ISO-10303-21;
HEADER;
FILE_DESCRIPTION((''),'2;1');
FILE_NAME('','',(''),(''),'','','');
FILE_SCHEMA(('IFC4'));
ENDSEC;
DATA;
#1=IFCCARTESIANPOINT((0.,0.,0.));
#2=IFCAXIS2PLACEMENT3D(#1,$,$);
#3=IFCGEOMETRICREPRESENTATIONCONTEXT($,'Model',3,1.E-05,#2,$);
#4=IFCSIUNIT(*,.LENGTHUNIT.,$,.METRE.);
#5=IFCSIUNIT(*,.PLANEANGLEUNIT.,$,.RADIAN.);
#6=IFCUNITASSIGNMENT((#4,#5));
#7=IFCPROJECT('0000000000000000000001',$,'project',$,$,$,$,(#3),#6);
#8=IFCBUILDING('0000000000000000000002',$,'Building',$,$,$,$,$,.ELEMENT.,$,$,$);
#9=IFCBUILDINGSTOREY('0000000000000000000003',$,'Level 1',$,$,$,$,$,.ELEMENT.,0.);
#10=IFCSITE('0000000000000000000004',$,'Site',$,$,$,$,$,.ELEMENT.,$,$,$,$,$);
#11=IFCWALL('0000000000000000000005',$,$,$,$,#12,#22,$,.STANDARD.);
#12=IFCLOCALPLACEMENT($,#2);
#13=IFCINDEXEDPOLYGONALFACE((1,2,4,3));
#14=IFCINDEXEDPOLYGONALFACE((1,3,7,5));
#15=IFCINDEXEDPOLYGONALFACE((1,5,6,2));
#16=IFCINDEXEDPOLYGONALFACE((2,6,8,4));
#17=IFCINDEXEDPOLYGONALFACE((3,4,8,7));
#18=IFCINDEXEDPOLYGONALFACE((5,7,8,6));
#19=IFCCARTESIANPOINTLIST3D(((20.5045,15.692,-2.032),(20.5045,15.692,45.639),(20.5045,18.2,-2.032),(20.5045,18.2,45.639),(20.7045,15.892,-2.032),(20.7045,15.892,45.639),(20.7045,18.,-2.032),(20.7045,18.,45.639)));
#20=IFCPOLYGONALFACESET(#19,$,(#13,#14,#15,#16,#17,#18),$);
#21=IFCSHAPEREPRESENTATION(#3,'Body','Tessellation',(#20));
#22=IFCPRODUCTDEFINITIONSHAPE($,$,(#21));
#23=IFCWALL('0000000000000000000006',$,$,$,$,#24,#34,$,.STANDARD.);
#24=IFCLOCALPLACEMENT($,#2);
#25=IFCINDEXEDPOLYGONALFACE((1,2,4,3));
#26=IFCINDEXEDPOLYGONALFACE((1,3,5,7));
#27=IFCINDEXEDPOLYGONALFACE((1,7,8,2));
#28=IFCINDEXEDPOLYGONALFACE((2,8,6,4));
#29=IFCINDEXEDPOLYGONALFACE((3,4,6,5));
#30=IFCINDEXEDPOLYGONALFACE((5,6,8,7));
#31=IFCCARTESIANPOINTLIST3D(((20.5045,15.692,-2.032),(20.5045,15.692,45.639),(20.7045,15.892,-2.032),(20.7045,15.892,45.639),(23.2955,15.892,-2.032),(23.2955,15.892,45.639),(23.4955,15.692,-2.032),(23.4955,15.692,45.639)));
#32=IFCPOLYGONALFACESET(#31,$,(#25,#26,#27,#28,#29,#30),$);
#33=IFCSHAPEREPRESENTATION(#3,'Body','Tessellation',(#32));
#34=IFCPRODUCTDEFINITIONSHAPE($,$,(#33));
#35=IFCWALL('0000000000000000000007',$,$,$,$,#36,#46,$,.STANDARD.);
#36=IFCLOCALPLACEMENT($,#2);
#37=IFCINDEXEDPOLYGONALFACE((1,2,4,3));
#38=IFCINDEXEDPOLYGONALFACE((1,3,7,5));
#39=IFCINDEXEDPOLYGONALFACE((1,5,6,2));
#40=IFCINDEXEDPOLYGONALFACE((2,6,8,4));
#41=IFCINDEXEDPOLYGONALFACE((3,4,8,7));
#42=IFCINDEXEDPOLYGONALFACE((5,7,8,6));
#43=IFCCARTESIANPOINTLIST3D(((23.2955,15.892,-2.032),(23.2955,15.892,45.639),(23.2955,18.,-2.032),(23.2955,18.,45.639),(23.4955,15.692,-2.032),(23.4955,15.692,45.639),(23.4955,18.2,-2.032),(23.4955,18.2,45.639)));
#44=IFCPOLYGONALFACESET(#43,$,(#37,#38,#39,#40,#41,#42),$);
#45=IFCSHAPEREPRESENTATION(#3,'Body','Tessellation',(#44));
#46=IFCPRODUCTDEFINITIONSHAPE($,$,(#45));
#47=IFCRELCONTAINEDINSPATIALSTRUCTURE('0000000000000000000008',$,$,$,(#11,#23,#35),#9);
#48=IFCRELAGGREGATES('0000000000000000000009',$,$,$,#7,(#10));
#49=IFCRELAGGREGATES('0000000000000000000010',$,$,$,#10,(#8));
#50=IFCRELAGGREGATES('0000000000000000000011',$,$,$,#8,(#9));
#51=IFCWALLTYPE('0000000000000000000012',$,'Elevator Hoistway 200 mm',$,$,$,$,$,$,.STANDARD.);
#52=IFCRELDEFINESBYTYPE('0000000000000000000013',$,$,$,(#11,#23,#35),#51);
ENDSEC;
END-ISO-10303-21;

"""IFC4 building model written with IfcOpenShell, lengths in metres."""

from ifc_helpers import new_model, si_unit, frame, origin, place, context, project, spatial, polyline, outline, extrude, type_object, element, save


model = new_model("IFC4")

# Units and contexts
model_context = context("Model", 3, precision=1e-05, world=origin())
ifc_project = project(units=[si_unit("LENGTHUNIT", "METRE"), si_unit("PLANEANGLEUNIT", "RADIAN")], contexts=[model_context])

# Site, building, storey
site = spatial("IfcSite", under=ifc_project, Name="Site", CompositionType="ELEMENT")
building = spatial("IfcBuilding", under=site, Name="Building", CompositionType="ELEMENT")
storey = spatial("IfcBuildingStorey", under=building, Name="Level 1", CompositionType="ELEMENT", Elevation=0.0)

# Shared definitions
wall_type = type_object("IfcWallType", Name="Elevator Hoistway 200 mm", PredefinedType="STANDARD")

# Walls
wall_1_placement = place(None, frame((20.6045, 18.1, -2.032), z_axis=(0.0, 0.0, 1.0), x_axis=(0.0, -1.0, 0.0)))
element("IfcWall", 1, at=wall_1_placement, inside=storey, type_object=wall_type, PredefinedType="STANDARD", context=model_context, shape_type="SweptSolid", body=[
    extrude(outline(polyline([(-0.1, -0.1), (2.408, -0.1), (2.208, 0.1), (0.1, 0.1), (-0.1, -0.1)])), origin(), (0.0, 0.0, 1.0), 47.671),
])
wall_2_placement = place(None, frame((20.6045, 15.792, -2.032), z_axis=(0.0, 0.0, 1.0), x_axis=(1.0, 0.0, 0.0)))
element("IfcWall", 2, at=wall_2_placement, inside=storey, type_object=wall_type, PredefinedType="STANDARD", context=model_context, shape_type="SweptSolid", body=[
    extrude(outline(polyline([(-0.1, -0.1), (2.891, -0.1), (2.691, 0.1), (0.1, 0.1), (-0.1, -0.1)])), origin(), (0.0, 0.0, 1.0), 47.671),
])
wall_3_placement = place(None, frame((23.3955, 15.792, -2.032), z_axis=(0.0, 0.0, 1.0), x_axis=(0.0, 1.0, 0.0)))
element("IfcWall", 3, at=wall_3_placement, inside=storey, type_object=wall_type, PredefinedType="STANDARD", context=model_context, shape_type="SweptSolid", body=[
    extrude(outline(polyline([(-0.1, -0.1), (2.408, -0.1), (2.208, 0.1), (0.1, 0.1), (-0.1, -0.1)])), origin(), (0.0, 0.0, 1.0), 47.671),
])

save(model, "model.ifc")
